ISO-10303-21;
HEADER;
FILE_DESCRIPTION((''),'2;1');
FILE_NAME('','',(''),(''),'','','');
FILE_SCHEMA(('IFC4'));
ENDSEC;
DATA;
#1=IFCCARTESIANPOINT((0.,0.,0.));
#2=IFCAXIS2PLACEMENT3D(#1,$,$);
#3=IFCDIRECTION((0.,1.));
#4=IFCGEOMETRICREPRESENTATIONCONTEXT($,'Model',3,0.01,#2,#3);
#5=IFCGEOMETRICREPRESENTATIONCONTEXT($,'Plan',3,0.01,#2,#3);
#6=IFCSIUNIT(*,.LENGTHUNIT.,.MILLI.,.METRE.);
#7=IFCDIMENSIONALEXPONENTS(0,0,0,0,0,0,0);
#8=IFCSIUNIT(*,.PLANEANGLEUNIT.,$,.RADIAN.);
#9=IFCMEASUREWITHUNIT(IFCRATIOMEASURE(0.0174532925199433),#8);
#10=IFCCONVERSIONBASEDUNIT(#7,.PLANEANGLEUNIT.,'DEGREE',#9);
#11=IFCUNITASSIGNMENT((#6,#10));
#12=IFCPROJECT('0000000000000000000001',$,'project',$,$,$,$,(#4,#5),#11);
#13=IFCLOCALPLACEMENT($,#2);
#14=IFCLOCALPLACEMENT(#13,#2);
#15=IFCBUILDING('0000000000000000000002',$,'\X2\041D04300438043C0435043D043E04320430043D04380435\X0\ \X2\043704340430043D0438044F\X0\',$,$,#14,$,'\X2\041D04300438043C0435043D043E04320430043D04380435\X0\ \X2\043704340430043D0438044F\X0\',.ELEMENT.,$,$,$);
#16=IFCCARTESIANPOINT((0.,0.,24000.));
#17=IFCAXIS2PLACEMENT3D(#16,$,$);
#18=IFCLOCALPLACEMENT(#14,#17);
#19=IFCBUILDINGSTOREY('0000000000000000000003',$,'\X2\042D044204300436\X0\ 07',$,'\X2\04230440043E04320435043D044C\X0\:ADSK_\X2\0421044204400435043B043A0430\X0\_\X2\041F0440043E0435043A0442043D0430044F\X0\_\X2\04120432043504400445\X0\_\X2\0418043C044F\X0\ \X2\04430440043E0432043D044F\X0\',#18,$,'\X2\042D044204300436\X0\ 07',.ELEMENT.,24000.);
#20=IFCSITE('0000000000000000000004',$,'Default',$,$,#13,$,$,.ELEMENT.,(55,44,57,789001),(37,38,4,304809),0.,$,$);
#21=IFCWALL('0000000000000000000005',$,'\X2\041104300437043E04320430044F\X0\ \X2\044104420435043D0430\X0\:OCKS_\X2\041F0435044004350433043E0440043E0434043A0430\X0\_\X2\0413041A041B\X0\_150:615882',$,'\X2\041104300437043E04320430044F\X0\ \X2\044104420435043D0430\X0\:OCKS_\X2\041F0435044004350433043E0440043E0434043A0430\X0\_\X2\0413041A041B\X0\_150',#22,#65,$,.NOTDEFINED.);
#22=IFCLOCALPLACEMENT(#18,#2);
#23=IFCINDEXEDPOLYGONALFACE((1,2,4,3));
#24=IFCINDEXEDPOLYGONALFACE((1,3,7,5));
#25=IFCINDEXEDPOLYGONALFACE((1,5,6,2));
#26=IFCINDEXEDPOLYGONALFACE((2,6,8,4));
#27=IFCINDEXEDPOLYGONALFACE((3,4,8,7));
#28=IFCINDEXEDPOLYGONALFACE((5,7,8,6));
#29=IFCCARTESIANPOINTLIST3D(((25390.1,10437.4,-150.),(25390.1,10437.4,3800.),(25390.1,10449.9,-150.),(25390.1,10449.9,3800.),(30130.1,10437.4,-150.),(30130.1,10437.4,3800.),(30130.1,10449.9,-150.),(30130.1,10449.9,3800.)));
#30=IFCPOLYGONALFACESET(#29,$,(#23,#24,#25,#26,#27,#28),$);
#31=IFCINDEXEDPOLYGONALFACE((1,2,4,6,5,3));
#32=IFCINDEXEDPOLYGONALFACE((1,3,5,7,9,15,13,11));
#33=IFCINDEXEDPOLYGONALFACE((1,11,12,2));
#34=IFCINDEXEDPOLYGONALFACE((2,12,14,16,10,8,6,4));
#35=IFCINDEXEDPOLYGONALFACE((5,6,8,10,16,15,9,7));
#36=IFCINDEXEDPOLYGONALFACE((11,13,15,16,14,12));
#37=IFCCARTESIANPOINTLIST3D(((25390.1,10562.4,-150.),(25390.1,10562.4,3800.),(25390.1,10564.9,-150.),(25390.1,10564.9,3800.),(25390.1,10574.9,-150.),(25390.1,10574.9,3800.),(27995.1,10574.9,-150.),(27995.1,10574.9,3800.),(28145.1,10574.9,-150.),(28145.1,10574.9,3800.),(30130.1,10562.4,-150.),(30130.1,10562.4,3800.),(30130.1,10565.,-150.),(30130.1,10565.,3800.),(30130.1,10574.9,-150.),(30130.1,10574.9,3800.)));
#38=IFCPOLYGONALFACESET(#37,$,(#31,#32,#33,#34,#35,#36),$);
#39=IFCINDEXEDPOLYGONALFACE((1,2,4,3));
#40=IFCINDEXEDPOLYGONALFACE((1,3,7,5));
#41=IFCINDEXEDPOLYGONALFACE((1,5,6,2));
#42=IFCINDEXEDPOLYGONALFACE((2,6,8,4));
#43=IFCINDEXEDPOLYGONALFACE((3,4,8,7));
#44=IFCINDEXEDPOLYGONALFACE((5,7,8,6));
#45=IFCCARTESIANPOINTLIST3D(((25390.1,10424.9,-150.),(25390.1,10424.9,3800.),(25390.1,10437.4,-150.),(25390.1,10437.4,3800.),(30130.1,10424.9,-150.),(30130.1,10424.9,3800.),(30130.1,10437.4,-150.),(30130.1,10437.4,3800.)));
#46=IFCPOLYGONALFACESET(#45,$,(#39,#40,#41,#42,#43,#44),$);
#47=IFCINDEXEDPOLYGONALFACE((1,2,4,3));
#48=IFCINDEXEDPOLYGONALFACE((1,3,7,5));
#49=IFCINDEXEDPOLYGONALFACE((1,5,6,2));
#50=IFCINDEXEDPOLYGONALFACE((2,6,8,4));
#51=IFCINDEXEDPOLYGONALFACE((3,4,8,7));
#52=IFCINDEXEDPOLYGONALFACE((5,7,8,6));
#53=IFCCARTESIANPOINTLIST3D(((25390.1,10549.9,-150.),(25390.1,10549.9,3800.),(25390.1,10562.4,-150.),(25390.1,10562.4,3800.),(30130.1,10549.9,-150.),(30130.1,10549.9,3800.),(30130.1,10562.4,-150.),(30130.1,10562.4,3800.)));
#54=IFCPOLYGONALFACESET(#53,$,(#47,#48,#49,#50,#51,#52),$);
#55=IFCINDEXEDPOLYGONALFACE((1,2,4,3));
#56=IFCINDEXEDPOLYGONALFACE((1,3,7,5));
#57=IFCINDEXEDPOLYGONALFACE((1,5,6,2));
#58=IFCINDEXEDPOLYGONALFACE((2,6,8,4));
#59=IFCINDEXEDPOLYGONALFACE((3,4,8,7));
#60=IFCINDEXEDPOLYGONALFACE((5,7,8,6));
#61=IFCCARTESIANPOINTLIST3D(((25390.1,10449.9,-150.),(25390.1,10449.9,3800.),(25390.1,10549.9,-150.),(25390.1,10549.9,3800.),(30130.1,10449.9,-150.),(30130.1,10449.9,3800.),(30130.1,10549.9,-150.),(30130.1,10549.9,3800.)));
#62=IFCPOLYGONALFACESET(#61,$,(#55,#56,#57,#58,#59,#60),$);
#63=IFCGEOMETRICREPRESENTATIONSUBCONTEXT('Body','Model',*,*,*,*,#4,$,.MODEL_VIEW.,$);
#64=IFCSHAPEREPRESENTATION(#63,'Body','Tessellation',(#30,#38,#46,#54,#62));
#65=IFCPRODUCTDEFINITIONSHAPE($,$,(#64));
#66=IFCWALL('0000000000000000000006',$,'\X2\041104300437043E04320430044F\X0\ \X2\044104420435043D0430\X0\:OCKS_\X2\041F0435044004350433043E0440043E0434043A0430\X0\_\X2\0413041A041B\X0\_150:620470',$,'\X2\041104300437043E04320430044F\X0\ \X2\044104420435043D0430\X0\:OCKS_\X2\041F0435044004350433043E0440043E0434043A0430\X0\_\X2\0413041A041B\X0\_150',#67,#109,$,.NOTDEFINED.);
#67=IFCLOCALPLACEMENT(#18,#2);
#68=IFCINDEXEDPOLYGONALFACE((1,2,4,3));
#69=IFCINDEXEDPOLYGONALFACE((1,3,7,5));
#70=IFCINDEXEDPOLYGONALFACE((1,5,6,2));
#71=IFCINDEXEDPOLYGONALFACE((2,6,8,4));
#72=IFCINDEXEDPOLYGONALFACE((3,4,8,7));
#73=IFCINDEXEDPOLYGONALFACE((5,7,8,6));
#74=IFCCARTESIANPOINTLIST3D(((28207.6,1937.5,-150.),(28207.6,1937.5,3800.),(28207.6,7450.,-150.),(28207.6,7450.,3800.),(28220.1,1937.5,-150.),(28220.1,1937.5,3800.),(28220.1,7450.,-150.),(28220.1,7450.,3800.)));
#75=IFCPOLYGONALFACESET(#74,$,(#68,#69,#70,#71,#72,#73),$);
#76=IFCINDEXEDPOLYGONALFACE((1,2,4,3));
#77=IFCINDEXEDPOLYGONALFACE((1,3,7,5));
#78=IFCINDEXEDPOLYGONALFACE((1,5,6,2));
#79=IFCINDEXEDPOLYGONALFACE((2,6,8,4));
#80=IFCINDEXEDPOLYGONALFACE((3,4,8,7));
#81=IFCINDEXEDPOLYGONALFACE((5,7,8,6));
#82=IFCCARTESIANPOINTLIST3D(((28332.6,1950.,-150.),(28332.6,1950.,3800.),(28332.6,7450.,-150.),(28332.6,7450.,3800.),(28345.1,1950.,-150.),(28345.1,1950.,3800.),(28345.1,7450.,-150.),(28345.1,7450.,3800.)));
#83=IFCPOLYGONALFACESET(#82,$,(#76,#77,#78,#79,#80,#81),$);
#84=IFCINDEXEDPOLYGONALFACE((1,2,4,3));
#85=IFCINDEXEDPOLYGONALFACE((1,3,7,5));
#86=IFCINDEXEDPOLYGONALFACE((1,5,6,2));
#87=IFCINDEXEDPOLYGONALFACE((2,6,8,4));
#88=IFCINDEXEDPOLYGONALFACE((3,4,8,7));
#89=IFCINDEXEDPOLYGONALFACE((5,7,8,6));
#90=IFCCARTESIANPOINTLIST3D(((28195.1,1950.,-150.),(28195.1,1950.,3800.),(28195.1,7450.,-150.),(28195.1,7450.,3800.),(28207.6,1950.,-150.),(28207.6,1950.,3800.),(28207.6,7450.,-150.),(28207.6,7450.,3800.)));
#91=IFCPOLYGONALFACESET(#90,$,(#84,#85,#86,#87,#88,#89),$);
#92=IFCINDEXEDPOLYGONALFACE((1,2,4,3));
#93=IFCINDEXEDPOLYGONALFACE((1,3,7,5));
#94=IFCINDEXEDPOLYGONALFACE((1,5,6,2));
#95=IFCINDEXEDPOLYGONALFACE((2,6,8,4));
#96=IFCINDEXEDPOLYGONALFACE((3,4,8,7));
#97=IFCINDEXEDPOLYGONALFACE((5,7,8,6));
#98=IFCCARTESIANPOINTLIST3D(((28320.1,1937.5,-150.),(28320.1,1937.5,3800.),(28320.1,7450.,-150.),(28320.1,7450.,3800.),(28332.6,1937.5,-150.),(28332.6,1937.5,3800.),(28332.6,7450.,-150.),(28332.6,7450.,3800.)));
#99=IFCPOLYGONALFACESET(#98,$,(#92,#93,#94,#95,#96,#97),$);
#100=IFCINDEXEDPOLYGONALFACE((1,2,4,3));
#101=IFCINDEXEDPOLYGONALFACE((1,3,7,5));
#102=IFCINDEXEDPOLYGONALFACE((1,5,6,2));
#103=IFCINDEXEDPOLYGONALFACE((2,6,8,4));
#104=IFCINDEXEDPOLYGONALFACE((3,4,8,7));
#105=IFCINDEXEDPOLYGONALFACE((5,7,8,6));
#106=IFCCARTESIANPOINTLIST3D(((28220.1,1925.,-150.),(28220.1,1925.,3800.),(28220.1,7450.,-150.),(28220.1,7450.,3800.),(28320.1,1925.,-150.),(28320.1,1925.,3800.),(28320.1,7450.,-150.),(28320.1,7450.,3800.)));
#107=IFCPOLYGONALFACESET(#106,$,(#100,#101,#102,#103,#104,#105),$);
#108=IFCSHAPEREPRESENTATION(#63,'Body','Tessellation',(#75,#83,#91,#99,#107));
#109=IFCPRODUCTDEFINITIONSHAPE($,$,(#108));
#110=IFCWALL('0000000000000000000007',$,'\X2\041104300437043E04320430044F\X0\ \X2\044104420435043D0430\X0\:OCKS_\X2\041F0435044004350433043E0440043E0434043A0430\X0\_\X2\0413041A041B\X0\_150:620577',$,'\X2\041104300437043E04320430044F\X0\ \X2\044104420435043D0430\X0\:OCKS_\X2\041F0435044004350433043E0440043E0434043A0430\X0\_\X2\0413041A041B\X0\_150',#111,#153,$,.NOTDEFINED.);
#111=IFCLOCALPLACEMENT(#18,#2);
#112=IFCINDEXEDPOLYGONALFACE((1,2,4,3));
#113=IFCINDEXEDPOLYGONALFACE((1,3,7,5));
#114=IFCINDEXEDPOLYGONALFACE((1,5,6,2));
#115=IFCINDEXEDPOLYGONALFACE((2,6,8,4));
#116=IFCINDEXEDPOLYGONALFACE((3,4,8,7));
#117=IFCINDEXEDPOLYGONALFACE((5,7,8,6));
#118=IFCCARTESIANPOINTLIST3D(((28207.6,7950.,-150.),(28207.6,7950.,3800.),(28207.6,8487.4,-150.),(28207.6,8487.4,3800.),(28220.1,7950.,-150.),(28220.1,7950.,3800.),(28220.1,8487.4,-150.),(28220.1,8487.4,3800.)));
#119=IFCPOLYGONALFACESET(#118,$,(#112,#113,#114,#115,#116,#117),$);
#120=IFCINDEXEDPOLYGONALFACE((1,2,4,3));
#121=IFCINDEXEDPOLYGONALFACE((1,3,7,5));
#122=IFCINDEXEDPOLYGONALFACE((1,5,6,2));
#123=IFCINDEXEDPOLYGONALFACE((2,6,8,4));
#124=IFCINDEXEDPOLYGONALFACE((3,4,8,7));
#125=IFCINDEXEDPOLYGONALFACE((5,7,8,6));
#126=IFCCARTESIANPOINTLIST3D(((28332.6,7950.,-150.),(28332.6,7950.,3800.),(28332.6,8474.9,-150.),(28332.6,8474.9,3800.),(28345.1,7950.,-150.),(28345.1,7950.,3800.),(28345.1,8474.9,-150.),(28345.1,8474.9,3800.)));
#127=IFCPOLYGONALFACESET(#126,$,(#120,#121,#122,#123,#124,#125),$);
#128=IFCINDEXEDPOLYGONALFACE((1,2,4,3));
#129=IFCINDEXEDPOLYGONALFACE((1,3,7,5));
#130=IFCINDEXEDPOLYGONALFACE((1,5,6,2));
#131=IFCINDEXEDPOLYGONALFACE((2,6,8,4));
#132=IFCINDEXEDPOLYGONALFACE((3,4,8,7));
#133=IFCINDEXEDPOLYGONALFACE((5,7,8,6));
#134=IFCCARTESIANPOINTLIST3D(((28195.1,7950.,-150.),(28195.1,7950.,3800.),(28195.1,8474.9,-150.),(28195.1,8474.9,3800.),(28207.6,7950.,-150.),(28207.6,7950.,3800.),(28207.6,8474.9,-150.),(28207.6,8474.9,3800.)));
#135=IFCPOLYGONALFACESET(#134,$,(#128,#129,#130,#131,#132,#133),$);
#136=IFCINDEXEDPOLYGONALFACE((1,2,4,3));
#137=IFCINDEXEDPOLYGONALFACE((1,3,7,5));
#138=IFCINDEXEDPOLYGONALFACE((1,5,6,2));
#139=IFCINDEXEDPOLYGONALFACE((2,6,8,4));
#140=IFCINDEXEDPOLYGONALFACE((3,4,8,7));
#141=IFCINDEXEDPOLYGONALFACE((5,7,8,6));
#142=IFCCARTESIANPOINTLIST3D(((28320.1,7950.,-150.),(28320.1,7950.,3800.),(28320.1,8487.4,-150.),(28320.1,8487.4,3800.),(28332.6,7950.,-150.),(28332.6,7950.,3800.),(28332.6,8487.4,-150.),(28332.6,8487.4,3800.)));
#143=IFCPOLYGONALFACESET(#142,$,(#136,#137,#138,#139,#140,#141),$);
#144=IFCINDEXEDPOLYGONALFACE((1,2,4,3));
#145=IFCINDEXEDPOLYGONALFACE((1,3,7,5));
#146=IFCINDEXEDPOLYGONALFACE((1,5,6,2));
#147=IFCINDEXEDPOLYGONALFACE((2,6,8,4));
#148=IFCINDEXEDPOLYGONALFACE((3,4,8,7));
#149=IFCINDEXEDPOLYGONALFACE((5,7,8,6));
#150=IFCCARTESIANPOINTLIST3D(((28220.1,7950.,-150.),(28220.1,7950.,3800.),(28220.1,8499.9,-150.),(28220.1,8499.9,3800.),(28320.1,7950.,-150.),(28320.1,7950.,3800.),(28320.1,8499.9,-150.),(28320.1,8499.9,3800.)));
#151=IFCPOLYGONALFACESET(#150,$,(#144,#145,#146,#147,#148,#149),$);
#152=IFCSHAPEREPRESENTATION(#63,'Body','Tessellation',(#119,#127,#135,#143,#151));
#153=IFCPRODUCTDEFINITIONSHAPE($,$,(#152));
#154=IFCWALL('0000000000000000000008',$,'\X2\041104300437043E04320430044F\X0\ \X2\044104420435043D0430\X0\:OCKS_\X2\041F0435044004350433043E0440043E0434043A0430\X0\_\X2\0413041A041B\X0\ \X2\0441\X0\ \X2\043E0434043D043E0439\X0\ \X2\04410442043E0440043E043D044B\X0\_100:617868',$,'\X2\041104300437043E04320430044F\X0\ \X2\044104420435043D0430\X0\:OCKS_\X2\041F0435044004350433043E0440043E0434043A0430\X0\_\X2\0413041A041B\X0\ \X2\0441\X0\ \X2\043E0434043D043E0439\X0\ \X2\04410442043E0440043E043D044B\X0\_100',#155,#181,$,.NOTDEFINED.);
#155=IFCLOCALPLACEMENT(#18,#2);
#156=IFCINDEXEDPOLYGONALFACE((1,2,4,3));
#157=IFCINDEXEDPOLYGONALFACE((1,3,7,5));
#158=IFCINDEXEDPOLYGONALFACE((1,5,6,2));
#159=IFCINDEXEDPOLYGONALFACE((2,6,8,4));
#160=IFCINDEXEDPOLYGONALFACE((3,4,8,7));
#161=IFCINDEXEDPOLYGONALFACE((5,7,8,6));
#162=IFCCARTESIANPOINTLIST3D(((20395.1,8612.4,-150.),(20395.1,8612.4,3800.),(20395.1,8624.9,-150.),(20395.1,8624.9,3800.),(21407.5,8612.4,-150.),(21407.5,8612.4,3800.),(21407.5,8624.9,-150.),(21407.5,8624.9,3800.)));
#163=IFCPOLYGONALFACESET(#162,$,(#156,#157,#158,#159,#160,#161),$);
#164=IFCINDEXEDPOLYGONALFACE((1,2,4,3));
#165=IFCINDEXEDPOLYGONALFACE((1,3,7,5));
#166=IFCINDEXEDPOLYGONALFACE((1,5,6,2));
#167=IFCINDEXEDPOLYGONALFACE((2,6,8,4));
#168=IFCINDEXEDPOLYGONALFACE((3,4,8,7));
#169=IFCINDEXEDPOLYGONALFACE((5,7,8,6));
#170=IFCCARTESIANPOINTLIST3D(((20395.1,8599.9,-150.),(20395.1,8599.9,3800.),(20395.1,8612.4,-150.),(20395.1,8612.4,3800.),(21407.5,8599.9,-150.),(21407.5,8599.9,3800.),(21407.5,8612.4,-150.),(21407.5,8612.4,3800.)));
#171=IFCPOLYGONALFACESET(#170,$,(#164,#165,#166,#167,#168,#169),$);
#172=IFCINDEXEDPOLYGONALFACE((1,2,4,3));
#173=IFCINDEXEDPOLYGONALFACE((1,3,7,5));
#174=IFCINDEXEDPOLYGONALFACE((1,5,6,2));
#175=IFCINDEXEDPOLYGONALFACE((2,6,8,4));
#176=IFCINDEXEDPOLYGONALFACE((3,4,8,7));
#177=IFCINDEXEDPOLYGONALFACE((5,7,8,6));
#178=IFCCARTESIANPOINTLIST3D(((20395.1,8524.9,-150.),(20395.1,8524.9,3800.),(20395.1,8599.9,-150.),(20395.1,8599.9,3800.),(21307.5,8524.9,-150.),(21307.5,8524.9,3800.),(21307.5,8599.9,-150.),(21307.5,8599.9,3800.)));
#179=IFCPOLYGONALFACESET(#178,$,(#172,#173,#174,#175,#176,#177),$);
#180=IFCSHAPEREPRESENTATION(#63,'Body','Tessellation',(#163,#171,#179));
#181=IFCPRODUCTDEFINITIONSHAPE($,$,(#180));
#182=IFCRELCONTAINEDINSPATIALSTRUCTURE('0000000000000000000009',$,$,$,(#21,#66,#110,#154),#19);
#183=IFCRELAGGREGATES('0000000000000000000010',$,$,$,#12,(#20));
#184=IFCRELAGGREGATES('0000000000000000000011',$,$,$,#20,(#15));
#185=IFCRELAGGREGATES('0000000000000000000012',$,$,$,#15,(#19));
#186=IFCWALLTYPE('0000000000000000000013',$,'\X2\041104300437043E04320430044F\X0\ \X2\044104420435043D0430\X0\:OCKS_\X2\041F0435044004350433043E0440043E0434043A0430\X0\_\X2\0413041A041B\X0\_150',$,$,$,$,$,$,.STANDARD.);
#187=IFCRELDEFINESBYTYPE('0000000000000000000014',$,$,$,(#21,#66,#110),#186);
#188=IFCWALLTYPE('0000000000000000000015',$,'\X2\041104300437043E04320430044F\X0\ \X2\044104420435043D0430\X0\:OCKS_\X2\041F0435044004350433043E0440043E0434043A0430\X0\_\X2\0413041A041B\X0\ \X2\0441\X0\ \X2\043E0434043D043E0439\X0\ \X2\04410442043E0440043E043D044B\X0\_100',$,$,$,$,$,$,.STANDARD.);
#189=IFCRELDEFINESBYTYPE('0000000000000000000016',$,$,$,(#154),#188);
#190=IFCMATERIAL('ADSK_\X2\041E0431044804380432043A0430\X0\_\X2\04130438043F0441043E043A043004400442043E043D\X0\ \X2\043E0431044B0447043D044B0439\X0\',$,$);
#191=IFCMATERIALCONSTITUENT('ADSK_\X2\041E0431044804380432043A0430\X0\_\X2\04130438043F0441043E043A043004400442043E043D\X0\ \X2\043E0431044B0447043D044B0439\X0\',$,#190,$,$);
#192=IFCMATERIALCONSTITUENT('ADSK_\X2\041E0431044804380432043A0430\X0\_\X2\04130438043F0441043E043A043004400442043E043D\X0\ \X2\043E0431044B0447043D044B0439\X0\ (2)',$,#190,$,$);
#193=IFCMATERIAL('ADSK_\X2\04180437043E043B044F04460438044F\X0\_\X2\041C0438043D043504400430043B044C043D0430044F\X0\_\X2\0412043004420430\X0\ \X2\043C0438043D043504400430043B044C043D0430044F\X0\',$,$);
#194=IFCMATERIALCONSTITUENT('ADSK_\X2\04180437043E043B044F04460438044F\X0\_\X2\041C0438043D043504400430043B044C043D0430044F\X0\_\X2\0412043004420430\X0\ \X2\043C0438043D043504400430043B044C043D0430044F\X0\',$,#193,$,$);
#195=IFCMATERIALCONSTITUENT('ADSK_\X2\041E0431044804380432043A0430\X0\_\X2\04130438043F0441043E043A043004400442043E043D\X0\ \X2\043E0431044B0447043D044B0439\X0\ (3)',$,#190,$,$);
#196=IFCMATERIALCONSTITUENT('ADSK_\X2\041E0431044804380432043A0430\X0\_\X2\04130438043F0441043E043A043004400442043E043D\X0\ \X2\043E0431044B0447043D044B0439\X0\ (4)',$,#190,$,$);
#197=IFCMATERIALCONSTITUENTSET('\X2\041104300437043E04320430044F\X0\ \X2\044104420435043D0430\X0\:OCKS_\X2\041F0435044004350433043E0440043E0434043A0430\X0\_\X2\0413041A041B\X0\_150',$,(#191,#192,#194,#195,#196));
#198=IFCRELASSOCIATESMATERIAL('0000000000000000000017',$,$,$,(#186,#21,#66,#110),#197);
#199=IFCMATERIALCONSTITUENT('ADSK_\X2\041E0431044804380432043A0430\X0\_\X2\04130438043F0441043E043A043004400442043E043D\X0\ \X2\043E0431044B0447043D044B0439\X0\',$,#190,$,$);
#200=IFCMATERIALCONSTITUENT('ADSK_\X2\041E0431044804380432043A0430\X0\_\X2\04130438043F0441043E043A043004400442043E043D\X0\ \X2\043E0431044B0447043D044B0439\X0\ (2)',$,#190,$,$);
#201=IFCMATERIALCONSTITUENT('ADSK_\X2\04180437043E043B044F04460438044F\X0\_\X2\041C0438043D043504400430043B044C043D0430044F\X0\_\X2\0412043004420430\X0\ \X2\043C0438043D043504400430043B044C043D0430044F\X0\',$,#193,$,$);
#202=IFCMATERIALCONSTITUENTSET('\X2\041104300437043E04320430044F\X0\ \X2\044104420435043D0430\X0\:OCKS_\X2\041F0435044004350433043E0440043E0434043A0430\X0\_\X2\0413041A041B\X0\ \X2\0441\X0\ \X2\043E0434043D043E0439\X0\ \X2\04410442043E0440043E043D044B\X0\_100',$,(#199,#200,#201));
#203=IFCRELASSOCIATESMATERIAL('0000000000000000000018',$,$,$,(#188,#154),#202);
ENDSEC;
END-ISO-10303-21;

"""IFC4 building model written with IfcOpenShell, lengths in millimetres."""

from ifc_helpers import new_model, entity, si_unit, converted_unit, direction, frame, origin, place, context, subcontext, project, spatial, indexed_curve, outline, extrude, material, constituent, constituent_set, type_object, element, save


model = new_model("IFC4")

# Units and contexts
model_context = context("Model", 3, precision=0.01, world=origin(), true_north=direction((0.0, 1.0)))
plan_context = context("Plan", 3, precision=0.01, world=origin(), true_north=direction((0.0, 1.0)))
body_context = subcontext(model_context, "Body", "Model", "MODEL_VIEW")
ifc_project = project(units=[si_unit("LENGTHUNIT", "METRE", prefix="MILLI"), converted_unit("PLANEANGLEUNIT", "DEGREE", entity("IfcRatioMeasure", 0.0174532925199433), si_unit("PLANEANGLEUNIT", "RADIAN"), dimensions=[0, 0, 0, 0, 0, 0, 0])], contexts=[model_context, plan_context])

# Site, building, storey
site_placement = place(None, frame((0.0, 0.0, 0.0)))
site = spatial("IfcSite", under=ifc_project, at=site_placement, Name="Default", CompositionType="ELEMENT", RefLatitude=(55, 44, 57, 789001), RefLongitude=(37, 38, 4, 304809), RefElevation=0.0)
building_placement = place(site_placement, origin())
building = spatial("IfcBuilding", under=site, at=building_placement, Name="Наименование здания", LongName="Наименование здания", CompositionType="ELEMENT")
storey_placement = place(building_placement, frame((0.0, 0.0, 24000.0)))
storey = spatial("IfcBuildingStorey", under=building, at=storey_placement, Name="Этаж 07", ObjectType="Уровень:ADSK_Стрелка_Проектная_Вверх_Имя уровня", LongName="Этаж 07", CompositionType="ELEMENT", Elevation=24000.0)

# Shared definitions
ifc_material_1 = material(Name="ADSK_Обшивка_Гипсокартон обычный")
ifc_constituent_1 = constituent(ifc_material_1, Name="ADSK_Обшивка_Гипсокартон обычный")
ifc_constituent_2 = constituent(ifc_material_1, Name="ADSK_Обшивка_Гипсокартон обычный (2)")
ifc_material_2 = material(Name="ADSK_Изоляция_Минеральная_Вата минеральная")
ifc_constituent_3 = constituent(ifc_material_2, Name="ADSK_Изоляция_Минеральная_Вата минеральная")
ifc_constituent_4 = constituent(ifc_material_1, Name="ADSK_Обшивка_Гипсокартон обычный (3)")
ifc_constituent_5 = constituent(ifc_material_1, Name="ADSK_Обшивка_Гипсокартон обычный (4)")
ifc_constituent_set_1 = constituent_set(constituents=[ifc_constituent_1, ifc_constituent_2, ifc_constituent_3, ifc_constituent_4, ifc_constituent_5], Name="Базовая стена:OCKS_Перегородка_ГКЛ_150")
wall_type_1 = type_object("IfcWallType", Name="Базовая стена:OCKS_Перегородка_ГКЛ_150", PredefinedType="STANDARD", material=ifc_constituent_set_1)

# Wall
wall_1_placement = place(storey_placement, frame((30130.1, 10499.9, -150.0), z_axis=(0.0, 0.0, 1.0), x_axis=(-1.0, 0.0, 0.0)))
element("IfcWall", 1, at=wall_1_placement, inside=storey, type_object=wall_type_1, material=ifc_constituent_set_1, Name="Базовая стена:OCKS_Перегородка_ГКЛ_150:615882", ObjectType="Базовая стена:OCKS_Перегородка_ГКЛ_150", PredefinedType="NOTDEFINED", context=body_context, shape_type="SweptSolid", body=[
    extrude(outline(indexed_curve([(-2370.0, -6.3), (2370.0, -6.3), (2370.0, 6.2), (-2370.0, 6.2), (-2370.0, -6.3)], self_intersect=False)), frame((2370.0, 56.3, 0.0)), (0.0, 0.0, 1.0), 3950.0),
    extrude(outline(indexed_curve([(-307.5, -5.6), (-157.5, -5.6), (2447.5, -5.6), (2447.5, 4.4), (2447.5, 6.9), (-2292.5, 6.9), (-2292.5, 4.3), (-2292.5, -5.6), (-307.5, -5.6)], self_intersect=False)), frame((2292.5, -69.4, 0.0)), (0.0, 0.0, 1.0), 3950.0),
    extrude(outline(indexed_curve([(-6.3, -2370.0), (6.2, -2370.0), (6.3, 2370.0), (-6.2, 2370.0), (-6.3, -2370.0)], self_intersect=False)), frame((2370.0, 68.8, 0.0), z_axis=(0.0, 0.0, 1.0), x_axis=(0.0, -1.0, 0.0)), (0.0, 0.0, 1.0), 3950.0),
    extrude(outline(indexed_curve([(-2370.0, -6.3), (2370.0, -6.3), (2370.0, 6.2), (-2370.0, 6.2), (-2370.0, -6.3)], self_intersect=False)), frame((2370.0, -56.2, 0.0)), (0.0, 0.0, 1.0), 3950.0),
    extrude(outline(indexed_curve([(-2370.0, -50.0), (2370.0, -50.0), (2370.0, 50.0), (-2370.0, 50.0), (-2370.0, -50.0)], self_intersect=False)), frame((2370.0, 0.0, 0.0)), (0.0, 0.0, 1.0), 3950.0),
])

# Walls
wall_2_placement = place(storey_placement, frame((28270.1, 1950.0, -150.0), z_axis=(0.0, 0.0, 1.0), x_axis=(0.0, 1.0, 0.0)))
element("IfcWall", 2, at=wall_2_placement, inside=storey, type_object=wall_type_1, material=ifc_constituent_set_1, Name="Базовая стена:OCKS_Перегородка_ГКЛ_150:620470", ObjectType="Базовая стена:OCKS_Перегородка_ГКЛ_150", PredefinedType="NOTDEFINED", context=body_context, shape_type="SweptSolid", body=[
    extrude(outline(indexed_curve([(-2756.3, -6.2), (2756.3, -6.2), (2756.3, 6.2), (-2756.3, 6.2), (-2756.3, -6.2)], self_intersect=False)), frame((2743.8, 56.2, 0.0)), (0.0, 0.0, 1.0), 3950.0),
    extrude(outline(indexed_curve([(-6.3, -2750.0), (6.2, -2750.0), (6.3, 2750.0), (-6.2, 2750.0), (-6.3, -2750.0)], self_intersect=False)), frame((2750.0, -68.8, 0.0), z_axis=(0.0, 0.0, 1.0), x_axis=(0.0, 1.0, 0.0)), (0.0, 0.0, 1.0), 3950.0),
    extrude(outline(indexed_curve([(-6.3, -2750.0), (6.2, -2750.0), (6.3, 2750.0), (-6.2, 2750.0), (-6.3, -2750.0)], self_intersect=False)), frame((2750.0, 68.7, 0.0), z_axis=(0.0, 0.0, 1.0), x_axis=(0.0, -1.0, 0.0)), (0.0, 0.0, 1.0), 3950.0),
    extrude(outline(indexed_curve([(-2756.3, -6.2), (2756.3, -6.2), (2756.3, 6.2), (-2756.3, 6.2), (-2756.3, -6.2)], self_intersect=False)), frame((2743.8, -56.3, 0.0)), (0.0, 0.0, 1.0), 3950.0),
    extrude(outline(indexed_curve([(-2762.5, -50.0), (2762.5, -50.0), (2762.5, 50.0), (-2762.5, 50.0), (-2762.5, -50.0)], self_intersect=False)), frame((2737.5, 0.0, 0.0)), (0.0, 0.0, 1.0), 3950.0),
])
wall_3_placement = place(storey_placement, frame((28270.1, 7950.0, -150.0), z_axis=(0.0, 0.0, 1.0), x_axis=(0.0, 1.0, 0.0)))
element("IfcWall", 3, at=wall_3_placement, inside=storey, type_object=wall_type_1, material=ifc_constituent_set_1, Name="Базовая стена:OCKS_Перегородка_ГКЛ_150:620577", ObjectType="Базовая стена:OCKS_Перегородка_ГКЛ_150", PredefinedType="NOTDEFINED", context=body_context, shape_type="SweptSolid", body=[
    extrude(outline(indexed_curve([(-268.7, -6.2), (268.7, -6.2), (268.7, 6.2), (-268.7, 6.2), (-268.7, -6.2)], self_intersect=False)), frame((268.7, 56.3, 0.0)), (0.0, 0.0, 1.0), 3950.0),
    extrude(outline(indexed_curve([(-6.3, -262.5), (6.2, -262.5), (6.2, 262.5), (-6.3, 262.5), (-6.3, -262.5)], self_intersect=False)), frame((262.5, -68.7, 0.0), z_axis=(0.0, 0.0, 1.0), x_axis=(0.0, 1.0, 0.0)), (0.0, 0.0, 1.0), 3950.0),
    extrude(outline(indexed_curve([(-6.3, -262.5), (6.2, -262.5), (6.2, 262.5), (-6.3, 262.5), (-6.3, -262.5)], self_intersect=False)), frame((262.5, 68.7, 0.0), z_axis=(0.0, 0.0, 1.0), x_axis=(0.0, -1.0, 0.0)), (0.0, 0.0, 1.0), 3950.0),
    extrude(outline(indexed_curve([(-268.7, -6.2), (268.7, -6.2), (268.7, 6.2), (-268.7, 6.2), (-268.7, -6.2)], self_intersect=False)), frame((268.7, -56.3, 0.0)), (0.0, 0.0, 1.0), 3950.0),
    extrude(outline(indexed_curve([(-275.0, -50.0), (275.0, -50.0), (275.0, 50.0), (-275.0, 50.0), (-275.0, -50.0)], self_intersect=False)), frame((275.0, 0.0, 0.0)), (0.0, 0.0, 1.0), 3950.0),
])

# Wall
ifc_constituent_6 = constituent(ifc_material_1, Name="ADSK_Обшивка_Гипсокартон обычный")
ifc_constituent_7 = constituent(ifc_material_1, Name="ADSK_Обшивка_Гипсокартон обычный (2)")
ifc_constituent_8 = constituent(ifc_material_2, Name="ADSK_Изоляция_Минеральная_Вата минеральная")
ifc_constituent_set_2 = constituent_set(constituents=[ifc_constituent_6, ifc_constituent_7, ifc_constituent_8], Name="Базовая стена:OCKS_Перегородка_ГКЛ с одной стороны_100")
wall_type_2 = type_object("IfcWallType", Name="Базовая стена:OCKS_Перегородка_ГКЛ с одной стороны_100", PredefinedType="STANDARD", material=ifc_constituent_set_2)
wall_4_placement = place(storey_placement, frame((21307.5, 8574.9, -150.0), z_axis=(0.0, 0.0, 1.0), x_axis=(-1.0, 0.0, 0.0)))
element("IfcWall", 4, at=wall_4_placement, inside=storey, type_object=wall_type_2, material=ifc_constituent_set_2, Name="Базовая стена:OCKS_Перегородка_ГКЛ с одной стороны_100:617868", ObjectType="Базовая стена:OCKS_Перегородка_ГКЛ с одной стороны_100", PredefinedType="NOTDEFINED", context=body_context, shape_type="SweptSolid", body=[
    extrude(outline(indexed_curve([(-6.3, -506.2), (6.2, -506.2), (6.3, 506.2), (-6.2, 506.2), (-6.3, -506.2)], self_intersect=False)), frame((406.2, -43.7, 0.0), z_axis=(0.0, 0.0, 1.0), x_axis=(0.0, 1.0, 0.0)), (0.0, 0.0, 1.0), 3950.0),
    extrude(outline(indexed_curve([(-506.2, -6.3), (506.2, -6.3), (506.2, 6.3), (-506.2, 6.3), (-506.2, -6.3)], self_intersect=False)), frame((406.2, -31.2, 0.0)), (0.0, 0.0, 1.0), 3950.0),
    extrude(outline(indexed_curve([(-37.5, -456.2), (37.5, -456.2), (37.5, 456.2), (-37.5, 456.2), (-37.5, -456.2)], self_intersect=False)), frame((456.2, 12.5, 0.0), z_axis=(0.0, 0.0, 1.0), x_axis=(0.0, -1.0, 0.0)), (0.0, 0.0, 1.0), 3950.0),
])

save(model, "model.ifc")
